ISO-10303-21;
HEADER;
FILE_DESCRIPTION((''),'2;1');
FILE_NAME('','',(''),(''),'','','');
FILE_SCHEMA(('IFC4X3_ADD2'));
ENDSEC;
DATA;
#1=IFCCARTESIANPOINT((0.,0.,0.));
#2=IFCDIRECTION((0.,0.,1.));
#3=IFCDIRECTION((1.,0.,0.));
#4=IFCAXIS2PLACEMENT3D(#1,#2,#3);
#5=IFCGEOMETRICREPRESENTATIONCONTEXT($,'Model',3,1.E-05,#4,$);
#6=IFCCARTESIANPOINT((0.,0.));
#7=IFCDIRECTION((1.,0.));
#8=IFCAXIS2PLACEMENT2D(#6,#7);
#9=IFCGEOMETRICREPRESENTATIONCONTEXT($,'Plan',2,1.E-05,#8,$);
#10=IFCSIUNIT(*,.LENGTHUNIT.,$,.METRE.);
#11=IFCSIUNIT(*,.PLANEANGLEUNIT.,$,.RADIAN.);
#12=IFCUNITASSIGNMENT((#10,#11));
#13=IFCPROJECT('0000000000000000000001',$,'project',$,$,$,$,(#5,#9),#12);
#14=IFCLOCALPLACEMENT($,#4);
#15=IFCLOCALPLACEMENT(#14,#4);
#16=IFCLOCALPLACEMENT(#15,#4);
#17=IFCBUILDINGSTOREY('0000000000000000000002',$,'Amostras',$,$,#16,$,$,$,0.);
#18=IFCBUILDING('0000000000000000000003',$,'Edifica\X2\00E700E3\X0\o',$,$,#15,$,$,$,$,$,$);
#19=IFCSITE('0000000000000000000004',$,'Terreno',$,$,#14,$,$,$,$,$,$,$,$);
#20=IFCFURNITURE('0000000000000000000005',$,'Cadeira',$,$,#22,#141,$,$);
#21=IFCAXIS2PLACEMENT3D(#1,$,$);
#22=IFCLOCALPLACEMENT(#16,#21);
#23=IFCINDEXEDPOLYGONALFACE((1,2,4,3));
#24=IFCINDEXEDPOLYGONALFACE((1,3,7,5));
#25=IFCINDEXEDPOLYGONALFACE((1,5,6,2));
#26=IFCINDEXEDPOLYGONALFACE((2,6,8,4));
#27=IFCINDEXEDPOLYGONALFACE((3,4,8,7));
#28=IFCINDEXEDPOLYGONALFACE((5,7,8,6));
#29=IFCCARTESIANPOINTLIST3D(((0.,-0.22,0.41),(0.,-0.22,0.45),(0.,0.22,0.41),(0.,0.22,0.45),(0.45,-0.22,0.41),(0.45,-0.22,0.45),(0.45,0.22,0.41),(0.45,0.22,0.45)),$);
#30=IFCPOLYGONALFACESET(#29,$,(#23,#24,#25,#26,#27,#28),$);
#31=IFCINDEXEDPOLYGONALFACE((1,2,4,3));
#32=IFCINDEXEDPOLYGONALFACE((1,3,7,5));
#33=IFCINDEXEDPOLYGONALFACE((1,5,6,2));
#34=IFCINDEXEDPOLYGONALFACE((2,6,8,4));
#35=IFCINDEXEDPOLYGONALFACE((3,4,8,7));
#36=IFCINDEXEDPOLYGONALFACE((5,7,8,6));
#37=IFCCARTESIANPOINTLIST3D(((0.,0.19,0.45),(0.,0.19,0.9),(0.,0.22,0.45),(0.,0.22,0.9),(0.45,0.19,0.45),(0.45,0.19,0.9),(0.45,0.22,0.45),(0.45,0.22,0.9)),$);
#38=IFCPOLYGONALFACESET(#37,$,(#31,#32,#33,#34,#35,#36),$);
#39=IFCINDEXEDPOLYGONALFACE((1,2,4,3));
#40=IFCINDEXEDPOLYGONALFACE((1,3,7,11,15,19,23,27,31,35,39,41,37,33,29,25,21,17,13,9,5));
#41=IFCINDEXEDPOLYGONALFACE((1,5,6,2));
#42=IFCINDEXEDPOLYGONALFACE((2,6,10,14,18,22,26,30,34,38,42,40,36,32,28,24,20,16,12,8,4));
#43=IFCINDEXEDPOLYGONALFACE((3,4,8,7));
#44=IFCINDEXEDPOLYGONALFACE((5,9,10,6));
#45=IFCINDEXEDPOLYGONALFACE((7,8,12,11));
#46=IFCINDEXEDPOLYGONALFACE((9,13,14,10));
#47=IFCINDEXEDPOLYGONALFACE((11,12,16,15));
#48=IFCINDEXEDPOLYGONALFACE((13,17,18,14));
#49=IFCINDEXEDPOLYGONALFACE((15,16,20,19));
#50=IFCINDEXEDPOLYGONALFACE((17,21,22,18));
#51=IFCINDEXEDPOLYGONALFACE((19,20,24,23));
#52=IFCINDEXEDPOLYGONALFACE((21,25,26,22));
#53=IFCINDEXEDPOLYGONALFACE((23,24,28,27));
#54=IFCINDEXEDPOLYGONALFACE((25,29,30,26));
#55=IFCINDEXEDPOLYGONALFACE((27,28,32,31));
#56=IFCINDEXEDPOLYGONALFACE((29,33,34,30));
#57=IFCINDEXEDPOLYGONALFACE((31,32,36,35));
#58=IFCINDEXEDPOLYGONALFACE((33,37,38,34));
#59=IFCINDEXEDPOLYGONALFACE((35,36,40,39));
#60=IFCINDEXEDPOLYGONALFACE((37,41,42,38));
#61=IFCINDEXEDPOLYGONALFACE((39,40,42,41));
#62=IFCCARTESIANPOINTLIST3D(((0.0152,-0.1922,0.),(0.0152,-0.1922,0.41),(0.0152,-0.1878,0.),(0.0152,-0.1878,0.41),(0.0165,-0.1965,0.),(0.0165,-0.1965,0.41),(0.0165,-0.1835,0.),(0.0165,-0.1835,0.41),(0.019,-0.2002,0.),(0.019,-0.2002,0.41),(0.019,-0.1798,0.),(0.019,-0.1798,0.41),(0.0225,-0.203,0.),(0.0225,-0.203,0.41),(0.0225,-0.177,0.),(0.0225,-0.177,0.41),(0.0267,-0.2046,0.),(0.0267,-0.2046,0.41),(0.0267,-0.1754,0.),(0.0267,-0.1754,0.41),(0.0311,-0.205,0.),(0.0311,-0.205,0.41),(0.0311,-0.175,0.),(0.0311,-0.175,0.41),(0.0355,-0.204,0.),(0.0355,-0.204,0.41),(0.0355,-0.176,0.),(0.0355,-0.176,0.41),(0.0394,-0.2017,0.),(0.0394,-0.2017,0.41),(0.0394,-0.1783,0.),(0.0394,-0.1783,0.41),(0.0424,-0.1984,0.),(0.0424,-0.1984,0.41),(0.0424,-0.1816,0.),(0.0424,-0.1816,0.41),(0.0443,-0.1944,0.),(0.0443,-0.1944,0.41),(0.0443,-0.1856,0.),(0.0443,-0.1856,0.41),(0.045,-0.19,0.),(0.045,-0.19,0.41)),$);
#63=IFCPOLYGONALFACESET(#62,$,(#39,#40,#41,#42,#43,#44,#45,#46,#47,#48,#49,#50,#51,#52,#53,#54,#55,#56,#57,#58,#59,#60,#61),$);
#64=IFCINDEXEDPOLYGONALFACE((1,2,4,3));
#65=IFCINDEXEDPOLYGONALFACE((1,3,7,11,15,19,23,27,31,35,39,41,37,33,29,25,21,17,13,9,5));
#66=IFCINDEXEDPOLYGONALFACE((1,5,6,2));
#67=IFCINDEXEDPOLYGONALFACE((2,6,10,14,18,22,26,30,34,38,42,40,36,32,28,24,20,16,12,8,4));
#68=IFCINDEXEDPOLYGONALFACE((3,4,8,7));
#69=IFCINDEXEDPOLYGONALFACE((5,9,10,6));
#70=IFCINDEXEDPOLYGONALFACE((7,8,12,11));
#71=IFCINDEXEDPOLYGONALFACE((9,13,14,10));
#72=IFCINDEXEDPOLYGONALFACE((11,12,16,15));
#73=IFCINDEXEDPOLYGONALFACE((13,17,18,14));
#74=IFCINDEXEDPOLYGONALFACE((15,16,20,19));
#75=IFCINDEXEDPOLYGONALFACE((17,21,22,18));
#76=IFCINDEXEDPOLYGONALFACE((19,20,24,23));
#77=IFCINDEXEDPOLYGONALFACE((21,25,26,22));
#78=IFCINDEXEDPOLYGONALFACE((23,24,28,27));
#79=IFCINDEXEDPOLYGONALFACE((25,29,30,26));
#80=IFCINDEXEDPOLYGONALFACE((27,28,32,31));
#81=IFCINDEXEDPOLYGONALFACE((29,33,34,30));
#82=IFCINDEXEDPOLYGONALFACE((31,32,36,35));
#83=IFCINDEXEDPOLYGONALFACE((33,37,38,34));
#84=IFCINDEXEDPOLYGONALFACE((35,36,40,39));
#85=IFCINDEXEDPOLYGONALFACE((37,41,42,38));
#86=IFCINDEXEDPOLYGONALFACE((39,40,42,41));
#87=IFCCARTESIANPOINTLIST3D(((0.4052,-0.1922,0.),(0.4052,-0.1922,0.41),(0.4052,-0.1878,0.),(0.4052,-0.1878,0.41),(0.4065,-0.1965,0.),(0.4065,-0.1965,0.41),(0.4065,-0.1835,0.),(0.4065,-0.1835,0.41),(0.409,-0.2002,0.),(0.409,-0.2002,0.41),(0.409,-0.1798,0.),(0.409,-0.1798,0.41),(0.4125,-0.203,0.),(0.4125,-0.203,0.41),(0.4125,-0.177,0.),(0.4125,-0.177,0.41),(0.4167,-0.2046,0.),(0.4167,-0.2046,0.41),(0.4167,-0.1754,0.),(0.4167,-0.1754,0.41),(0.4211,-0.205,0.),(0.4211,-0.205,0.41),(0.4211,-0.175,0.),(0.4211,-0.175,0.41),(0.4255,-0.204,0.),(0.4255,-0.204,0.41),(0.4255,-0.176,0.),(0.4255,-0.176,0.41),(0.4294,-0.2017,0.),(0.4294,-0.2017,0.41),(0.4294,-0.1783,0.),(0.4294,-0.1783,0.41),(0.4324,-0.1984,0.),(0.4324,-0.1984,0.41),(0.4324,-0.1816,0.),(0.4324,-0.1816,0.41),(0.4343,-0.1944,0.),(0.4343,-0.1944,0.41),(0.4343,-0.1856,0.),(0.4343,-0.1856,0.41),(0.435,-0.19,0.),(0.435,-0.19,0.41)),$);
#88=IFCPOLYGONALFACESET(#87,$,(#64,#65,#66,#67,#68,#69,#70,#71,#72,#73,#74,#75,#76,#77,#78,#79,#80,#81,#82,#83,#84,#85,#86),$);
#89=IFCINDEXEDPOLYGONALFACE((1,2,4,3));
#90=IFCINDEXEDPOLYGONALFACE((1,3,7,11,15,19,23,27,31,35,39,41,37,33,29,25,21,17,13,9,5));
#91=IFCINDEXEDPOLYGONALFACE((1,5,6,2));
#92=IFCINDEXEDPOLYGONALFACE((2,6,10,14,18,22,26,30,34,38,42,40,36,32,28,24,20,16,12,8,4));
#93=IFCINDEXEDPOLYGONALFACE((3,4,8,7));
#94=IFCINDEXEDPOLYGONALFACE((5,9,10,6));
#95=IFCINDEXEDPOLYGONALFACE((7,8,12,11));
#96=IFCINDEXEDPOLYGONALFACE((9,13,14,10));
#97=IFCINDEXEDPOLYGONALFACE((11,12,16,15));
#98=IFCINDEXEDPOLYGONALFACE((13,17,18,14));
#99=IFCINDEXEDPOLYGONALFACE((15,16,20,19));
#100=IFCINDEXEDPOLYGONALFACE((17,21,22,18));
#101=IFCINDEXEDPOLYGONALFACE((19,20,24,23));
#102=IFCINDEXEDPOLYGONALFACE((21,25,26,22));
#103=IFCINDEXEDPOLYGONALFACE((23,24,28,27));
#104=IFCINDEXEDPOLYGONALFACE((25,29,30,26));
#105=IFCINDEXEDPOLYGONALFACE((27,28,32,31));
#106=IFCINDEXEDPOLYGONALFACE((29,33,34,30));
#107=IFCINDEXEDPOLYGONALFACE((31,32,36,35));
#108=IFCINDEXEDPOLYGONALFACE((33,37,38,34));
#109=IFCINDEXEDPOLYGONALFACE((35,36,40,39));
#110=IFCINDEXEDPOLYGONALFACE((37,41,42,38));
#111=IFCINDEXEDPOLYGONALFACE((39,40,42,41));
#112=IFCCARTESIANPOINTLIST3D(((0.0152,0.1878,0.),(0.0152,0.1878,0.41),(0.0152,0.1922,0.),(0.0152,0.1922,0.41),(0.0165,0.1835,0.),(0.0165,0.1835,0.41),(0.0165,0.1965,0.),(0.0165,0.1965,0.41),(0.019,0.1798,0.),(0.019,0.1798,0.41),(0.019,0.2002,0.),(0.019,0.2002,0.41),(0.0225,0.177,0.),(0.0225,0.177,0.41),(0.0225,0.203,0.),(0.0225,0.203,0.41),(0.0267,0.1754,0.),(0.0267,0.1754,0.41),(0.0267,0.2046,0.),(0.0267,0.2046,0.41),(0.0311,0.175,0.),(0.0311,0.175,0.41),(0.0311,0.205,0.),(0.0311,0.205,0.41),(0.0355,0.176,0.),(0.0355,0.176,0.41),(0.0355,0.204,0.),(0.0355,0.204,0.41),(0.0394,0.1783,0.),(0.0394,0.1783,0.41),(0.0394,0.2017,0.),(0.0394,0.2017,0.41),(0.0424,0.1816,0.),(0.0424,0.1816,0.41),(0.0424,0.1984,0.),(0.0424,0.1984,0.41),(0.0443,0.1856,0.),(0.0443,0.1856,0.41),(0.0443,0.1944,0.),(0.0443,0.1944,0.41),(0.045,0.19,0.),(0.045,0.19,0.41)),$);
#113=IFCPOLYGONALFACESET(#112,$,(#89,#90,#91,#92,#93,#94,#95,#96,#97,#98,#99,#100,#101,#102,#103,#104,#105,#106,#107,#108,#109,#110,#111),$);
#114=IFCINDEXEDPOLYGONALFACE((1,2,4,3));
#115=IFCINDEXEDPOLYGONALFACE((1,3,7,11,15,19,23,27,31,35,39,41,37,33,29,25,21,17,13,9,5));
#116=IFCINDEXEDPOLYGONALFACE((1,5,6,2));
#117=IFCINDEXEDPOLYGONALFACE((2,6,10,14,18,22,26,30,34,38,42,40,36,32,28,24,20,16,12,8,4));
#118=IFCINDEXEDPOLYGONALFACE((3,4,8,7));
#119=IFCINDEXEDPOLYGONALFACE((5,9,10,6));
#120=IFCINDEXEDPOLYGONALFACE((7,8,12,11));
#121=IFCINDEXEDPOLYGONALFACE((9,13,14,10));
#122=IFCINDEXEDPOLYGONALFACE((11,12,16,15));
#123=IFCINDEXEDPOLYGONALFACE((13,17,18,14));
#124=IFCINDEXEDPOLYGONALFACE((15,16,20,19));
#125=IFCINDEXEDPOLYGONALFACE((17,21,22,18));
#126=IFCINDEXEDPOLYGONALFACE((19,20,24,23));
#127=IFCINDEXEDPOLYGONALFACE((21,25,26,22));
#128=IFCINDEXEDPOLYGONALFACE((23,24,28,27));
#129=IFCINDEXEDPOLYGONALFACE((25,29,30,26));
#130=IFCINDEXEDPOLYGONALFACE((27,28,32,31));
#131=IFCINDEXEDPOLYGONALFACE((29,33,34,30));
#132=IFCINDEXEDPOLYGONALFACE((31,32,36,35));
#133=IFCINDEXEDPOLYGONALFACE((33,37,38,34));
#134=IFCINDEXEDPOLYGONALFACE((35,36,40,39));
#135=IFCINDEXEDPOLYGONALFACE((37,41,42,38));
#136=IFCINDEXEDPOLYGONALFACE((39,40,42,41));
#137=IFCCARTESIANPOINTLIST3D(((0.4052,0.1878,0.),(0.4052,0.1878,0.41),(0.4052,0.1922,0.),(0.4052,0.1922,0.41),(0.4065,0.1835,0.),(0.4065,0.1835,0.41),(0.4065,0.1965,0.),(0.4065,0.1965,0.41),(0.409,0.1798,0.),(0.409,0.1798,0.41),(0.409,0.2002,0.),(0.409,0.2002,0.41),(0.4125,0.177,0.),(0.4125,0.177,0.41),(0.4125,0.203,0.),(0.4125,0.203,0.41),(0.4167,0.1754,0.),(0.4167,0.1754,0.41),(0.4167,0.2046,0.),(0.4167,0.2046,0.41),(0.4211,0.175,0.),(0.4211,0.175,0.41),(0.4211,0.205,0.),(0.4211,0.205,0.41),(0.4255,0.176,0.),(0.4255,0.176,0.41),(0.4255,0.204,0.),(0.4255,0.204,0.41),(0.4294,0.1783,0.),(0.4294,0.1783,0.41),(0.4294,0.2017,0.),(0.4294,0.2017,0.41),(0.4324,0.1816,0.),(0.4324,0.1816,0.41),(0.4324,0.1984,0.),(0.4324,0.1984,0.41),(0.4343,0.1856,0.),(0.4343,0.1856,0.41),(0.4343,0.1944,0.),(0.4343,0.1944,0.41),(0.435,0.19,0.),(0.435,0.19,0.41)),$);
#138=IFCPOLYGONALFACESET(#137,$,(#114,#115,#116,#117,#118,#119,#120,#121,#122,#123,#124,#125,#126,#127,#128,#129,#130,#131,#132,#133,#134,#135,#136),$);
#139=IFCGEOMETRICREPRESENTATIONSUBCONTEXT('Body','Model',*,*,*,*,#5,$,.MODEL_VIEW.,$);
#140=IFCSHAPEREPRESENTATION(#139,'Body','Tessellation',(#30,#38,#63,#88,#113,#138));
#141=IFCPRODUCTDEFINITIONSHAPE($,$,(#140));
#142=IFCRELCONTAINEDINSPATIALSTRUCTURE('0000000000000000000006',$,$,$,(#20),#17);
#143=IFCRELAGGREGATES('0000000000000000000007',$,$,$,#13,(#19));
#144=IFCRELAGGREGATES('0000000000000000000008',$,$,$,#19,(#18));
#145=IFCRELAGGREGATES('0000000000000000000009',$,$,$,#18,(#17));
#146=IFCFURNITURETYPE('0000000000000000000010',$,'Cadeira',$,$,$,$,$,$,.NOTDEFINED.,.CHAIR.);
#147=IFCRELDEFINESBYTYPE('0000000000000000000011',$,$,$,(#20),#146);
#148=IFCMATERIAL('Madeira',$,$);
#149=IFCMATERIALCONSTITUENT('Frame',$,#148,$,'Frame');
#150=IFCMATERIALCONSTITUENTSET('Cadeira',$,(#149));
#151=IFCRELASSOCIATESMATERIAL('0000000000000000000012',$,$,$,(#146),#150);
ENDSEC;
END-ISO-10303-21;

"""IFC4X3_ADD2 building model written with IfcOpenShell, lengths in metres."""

from ifc_helpers import new_model, si_unit, frame, frame_2d, origin_with_axes, origin_2d_with_axis, place, context, subcontext, project, spatial, rectangle, circle, extrude, material, constituent, constituent_set, type_object, element, save


model = new_model("IFC4X3_ADD2")

# Units and contexts
model_context = context("Model", 3, precision=1e-05, world=origin_with_axes())
plan_context = context("Plan", 2, precision=1e-05, world=origin_2d_with_axis())
body_context = subcontext(model_context, "Body", "Model", "MODEL_VIEW")
ifc_project = project(units=[si_unit("LENGTHUNIT", "METRE"), si_unit("PLANEANGLEUNIT", "RADIAN")], contexts=[model_context, plan_context])

# Site, building, storey
site_placement = place(None, origin_with_axes())
site = spatial("IfcSite", under=ifc_project, at=site_placement, Name="Terreno")
building_placement = place(site_placement, origin_with_axes())
building = spatial("IfcBuilding", under=site, at=building_placement, Name="Edificação")
storey_placement = place(building_placement, origin_with_axes())
storey = spatial("IfcBuildingStorey", under=building, at=storey_placement, Name="Amostras", Elevation=0.0)

# Furniture
ifc_material = material(Name="Madeira")
ifc_constituent_1 = constituent(ifc_material, Name="Frame", Category="Frame")
ifc_constituent_set_1 = constituent_set(constituents=[ifc_constituent_1], Name="Cadeira")
furniture_type_1 = type_object("IfcFurnitureType", Name="Cadeira", AssemblyPlace="NOTDEFINED", PredefinedType="CHAIR", material=ifc_constituent_set_1)
furniture_1_placement = place(storey_placement, frame((0.225, 0.0, 0.0), z_axis=(0.0, 0.0, 1.0), x_axis=(1.0, 0.0, 0.0)))
element("IfcFurniture", 1, at=furniture_1_placement, inside=storey, type_object=furniture_type_1, Name="Cadeira", context=body_context, shape_type="SweptSolid", body=[
    extrude(rectangle(XDim=0.45, YDim=0.44, at=origin_2d_with_axis()), frame((0.0, 0.0, 0.41)), (0.0, 0.0, 1.0), 0.04),
    extrude(rectangle(XDim=0.45, YDim=0.03, at=frame_2d((0.0, 0.205), x_axis=(1.0, 0.0))), frame((0.0, 0.0, 0.45)), (0.0, 0.0, 1.0), 0.45),
    extrude(circle(Radius=0.015), frame((-0.195, -0.19, 0.0)), (0.0, 0.0, 1.0), 0.41),
    extrude(circle(Radius=0.015), frame((0.195, -0.19, 0.0)), (0.0, 0.0, 1.0), 0.41),
    extrude(circle(Radius=0.015), frame((-0.195, 0.19, 0.0)), (0.0, 0.0, 1.0), 0.41),
    extrude(circle(Radius=0.015), frame((0.195, 0.19, 0.0)), (0.0, 0.0, 1.0), 0.41),
])

save(model, "model.ifc")
